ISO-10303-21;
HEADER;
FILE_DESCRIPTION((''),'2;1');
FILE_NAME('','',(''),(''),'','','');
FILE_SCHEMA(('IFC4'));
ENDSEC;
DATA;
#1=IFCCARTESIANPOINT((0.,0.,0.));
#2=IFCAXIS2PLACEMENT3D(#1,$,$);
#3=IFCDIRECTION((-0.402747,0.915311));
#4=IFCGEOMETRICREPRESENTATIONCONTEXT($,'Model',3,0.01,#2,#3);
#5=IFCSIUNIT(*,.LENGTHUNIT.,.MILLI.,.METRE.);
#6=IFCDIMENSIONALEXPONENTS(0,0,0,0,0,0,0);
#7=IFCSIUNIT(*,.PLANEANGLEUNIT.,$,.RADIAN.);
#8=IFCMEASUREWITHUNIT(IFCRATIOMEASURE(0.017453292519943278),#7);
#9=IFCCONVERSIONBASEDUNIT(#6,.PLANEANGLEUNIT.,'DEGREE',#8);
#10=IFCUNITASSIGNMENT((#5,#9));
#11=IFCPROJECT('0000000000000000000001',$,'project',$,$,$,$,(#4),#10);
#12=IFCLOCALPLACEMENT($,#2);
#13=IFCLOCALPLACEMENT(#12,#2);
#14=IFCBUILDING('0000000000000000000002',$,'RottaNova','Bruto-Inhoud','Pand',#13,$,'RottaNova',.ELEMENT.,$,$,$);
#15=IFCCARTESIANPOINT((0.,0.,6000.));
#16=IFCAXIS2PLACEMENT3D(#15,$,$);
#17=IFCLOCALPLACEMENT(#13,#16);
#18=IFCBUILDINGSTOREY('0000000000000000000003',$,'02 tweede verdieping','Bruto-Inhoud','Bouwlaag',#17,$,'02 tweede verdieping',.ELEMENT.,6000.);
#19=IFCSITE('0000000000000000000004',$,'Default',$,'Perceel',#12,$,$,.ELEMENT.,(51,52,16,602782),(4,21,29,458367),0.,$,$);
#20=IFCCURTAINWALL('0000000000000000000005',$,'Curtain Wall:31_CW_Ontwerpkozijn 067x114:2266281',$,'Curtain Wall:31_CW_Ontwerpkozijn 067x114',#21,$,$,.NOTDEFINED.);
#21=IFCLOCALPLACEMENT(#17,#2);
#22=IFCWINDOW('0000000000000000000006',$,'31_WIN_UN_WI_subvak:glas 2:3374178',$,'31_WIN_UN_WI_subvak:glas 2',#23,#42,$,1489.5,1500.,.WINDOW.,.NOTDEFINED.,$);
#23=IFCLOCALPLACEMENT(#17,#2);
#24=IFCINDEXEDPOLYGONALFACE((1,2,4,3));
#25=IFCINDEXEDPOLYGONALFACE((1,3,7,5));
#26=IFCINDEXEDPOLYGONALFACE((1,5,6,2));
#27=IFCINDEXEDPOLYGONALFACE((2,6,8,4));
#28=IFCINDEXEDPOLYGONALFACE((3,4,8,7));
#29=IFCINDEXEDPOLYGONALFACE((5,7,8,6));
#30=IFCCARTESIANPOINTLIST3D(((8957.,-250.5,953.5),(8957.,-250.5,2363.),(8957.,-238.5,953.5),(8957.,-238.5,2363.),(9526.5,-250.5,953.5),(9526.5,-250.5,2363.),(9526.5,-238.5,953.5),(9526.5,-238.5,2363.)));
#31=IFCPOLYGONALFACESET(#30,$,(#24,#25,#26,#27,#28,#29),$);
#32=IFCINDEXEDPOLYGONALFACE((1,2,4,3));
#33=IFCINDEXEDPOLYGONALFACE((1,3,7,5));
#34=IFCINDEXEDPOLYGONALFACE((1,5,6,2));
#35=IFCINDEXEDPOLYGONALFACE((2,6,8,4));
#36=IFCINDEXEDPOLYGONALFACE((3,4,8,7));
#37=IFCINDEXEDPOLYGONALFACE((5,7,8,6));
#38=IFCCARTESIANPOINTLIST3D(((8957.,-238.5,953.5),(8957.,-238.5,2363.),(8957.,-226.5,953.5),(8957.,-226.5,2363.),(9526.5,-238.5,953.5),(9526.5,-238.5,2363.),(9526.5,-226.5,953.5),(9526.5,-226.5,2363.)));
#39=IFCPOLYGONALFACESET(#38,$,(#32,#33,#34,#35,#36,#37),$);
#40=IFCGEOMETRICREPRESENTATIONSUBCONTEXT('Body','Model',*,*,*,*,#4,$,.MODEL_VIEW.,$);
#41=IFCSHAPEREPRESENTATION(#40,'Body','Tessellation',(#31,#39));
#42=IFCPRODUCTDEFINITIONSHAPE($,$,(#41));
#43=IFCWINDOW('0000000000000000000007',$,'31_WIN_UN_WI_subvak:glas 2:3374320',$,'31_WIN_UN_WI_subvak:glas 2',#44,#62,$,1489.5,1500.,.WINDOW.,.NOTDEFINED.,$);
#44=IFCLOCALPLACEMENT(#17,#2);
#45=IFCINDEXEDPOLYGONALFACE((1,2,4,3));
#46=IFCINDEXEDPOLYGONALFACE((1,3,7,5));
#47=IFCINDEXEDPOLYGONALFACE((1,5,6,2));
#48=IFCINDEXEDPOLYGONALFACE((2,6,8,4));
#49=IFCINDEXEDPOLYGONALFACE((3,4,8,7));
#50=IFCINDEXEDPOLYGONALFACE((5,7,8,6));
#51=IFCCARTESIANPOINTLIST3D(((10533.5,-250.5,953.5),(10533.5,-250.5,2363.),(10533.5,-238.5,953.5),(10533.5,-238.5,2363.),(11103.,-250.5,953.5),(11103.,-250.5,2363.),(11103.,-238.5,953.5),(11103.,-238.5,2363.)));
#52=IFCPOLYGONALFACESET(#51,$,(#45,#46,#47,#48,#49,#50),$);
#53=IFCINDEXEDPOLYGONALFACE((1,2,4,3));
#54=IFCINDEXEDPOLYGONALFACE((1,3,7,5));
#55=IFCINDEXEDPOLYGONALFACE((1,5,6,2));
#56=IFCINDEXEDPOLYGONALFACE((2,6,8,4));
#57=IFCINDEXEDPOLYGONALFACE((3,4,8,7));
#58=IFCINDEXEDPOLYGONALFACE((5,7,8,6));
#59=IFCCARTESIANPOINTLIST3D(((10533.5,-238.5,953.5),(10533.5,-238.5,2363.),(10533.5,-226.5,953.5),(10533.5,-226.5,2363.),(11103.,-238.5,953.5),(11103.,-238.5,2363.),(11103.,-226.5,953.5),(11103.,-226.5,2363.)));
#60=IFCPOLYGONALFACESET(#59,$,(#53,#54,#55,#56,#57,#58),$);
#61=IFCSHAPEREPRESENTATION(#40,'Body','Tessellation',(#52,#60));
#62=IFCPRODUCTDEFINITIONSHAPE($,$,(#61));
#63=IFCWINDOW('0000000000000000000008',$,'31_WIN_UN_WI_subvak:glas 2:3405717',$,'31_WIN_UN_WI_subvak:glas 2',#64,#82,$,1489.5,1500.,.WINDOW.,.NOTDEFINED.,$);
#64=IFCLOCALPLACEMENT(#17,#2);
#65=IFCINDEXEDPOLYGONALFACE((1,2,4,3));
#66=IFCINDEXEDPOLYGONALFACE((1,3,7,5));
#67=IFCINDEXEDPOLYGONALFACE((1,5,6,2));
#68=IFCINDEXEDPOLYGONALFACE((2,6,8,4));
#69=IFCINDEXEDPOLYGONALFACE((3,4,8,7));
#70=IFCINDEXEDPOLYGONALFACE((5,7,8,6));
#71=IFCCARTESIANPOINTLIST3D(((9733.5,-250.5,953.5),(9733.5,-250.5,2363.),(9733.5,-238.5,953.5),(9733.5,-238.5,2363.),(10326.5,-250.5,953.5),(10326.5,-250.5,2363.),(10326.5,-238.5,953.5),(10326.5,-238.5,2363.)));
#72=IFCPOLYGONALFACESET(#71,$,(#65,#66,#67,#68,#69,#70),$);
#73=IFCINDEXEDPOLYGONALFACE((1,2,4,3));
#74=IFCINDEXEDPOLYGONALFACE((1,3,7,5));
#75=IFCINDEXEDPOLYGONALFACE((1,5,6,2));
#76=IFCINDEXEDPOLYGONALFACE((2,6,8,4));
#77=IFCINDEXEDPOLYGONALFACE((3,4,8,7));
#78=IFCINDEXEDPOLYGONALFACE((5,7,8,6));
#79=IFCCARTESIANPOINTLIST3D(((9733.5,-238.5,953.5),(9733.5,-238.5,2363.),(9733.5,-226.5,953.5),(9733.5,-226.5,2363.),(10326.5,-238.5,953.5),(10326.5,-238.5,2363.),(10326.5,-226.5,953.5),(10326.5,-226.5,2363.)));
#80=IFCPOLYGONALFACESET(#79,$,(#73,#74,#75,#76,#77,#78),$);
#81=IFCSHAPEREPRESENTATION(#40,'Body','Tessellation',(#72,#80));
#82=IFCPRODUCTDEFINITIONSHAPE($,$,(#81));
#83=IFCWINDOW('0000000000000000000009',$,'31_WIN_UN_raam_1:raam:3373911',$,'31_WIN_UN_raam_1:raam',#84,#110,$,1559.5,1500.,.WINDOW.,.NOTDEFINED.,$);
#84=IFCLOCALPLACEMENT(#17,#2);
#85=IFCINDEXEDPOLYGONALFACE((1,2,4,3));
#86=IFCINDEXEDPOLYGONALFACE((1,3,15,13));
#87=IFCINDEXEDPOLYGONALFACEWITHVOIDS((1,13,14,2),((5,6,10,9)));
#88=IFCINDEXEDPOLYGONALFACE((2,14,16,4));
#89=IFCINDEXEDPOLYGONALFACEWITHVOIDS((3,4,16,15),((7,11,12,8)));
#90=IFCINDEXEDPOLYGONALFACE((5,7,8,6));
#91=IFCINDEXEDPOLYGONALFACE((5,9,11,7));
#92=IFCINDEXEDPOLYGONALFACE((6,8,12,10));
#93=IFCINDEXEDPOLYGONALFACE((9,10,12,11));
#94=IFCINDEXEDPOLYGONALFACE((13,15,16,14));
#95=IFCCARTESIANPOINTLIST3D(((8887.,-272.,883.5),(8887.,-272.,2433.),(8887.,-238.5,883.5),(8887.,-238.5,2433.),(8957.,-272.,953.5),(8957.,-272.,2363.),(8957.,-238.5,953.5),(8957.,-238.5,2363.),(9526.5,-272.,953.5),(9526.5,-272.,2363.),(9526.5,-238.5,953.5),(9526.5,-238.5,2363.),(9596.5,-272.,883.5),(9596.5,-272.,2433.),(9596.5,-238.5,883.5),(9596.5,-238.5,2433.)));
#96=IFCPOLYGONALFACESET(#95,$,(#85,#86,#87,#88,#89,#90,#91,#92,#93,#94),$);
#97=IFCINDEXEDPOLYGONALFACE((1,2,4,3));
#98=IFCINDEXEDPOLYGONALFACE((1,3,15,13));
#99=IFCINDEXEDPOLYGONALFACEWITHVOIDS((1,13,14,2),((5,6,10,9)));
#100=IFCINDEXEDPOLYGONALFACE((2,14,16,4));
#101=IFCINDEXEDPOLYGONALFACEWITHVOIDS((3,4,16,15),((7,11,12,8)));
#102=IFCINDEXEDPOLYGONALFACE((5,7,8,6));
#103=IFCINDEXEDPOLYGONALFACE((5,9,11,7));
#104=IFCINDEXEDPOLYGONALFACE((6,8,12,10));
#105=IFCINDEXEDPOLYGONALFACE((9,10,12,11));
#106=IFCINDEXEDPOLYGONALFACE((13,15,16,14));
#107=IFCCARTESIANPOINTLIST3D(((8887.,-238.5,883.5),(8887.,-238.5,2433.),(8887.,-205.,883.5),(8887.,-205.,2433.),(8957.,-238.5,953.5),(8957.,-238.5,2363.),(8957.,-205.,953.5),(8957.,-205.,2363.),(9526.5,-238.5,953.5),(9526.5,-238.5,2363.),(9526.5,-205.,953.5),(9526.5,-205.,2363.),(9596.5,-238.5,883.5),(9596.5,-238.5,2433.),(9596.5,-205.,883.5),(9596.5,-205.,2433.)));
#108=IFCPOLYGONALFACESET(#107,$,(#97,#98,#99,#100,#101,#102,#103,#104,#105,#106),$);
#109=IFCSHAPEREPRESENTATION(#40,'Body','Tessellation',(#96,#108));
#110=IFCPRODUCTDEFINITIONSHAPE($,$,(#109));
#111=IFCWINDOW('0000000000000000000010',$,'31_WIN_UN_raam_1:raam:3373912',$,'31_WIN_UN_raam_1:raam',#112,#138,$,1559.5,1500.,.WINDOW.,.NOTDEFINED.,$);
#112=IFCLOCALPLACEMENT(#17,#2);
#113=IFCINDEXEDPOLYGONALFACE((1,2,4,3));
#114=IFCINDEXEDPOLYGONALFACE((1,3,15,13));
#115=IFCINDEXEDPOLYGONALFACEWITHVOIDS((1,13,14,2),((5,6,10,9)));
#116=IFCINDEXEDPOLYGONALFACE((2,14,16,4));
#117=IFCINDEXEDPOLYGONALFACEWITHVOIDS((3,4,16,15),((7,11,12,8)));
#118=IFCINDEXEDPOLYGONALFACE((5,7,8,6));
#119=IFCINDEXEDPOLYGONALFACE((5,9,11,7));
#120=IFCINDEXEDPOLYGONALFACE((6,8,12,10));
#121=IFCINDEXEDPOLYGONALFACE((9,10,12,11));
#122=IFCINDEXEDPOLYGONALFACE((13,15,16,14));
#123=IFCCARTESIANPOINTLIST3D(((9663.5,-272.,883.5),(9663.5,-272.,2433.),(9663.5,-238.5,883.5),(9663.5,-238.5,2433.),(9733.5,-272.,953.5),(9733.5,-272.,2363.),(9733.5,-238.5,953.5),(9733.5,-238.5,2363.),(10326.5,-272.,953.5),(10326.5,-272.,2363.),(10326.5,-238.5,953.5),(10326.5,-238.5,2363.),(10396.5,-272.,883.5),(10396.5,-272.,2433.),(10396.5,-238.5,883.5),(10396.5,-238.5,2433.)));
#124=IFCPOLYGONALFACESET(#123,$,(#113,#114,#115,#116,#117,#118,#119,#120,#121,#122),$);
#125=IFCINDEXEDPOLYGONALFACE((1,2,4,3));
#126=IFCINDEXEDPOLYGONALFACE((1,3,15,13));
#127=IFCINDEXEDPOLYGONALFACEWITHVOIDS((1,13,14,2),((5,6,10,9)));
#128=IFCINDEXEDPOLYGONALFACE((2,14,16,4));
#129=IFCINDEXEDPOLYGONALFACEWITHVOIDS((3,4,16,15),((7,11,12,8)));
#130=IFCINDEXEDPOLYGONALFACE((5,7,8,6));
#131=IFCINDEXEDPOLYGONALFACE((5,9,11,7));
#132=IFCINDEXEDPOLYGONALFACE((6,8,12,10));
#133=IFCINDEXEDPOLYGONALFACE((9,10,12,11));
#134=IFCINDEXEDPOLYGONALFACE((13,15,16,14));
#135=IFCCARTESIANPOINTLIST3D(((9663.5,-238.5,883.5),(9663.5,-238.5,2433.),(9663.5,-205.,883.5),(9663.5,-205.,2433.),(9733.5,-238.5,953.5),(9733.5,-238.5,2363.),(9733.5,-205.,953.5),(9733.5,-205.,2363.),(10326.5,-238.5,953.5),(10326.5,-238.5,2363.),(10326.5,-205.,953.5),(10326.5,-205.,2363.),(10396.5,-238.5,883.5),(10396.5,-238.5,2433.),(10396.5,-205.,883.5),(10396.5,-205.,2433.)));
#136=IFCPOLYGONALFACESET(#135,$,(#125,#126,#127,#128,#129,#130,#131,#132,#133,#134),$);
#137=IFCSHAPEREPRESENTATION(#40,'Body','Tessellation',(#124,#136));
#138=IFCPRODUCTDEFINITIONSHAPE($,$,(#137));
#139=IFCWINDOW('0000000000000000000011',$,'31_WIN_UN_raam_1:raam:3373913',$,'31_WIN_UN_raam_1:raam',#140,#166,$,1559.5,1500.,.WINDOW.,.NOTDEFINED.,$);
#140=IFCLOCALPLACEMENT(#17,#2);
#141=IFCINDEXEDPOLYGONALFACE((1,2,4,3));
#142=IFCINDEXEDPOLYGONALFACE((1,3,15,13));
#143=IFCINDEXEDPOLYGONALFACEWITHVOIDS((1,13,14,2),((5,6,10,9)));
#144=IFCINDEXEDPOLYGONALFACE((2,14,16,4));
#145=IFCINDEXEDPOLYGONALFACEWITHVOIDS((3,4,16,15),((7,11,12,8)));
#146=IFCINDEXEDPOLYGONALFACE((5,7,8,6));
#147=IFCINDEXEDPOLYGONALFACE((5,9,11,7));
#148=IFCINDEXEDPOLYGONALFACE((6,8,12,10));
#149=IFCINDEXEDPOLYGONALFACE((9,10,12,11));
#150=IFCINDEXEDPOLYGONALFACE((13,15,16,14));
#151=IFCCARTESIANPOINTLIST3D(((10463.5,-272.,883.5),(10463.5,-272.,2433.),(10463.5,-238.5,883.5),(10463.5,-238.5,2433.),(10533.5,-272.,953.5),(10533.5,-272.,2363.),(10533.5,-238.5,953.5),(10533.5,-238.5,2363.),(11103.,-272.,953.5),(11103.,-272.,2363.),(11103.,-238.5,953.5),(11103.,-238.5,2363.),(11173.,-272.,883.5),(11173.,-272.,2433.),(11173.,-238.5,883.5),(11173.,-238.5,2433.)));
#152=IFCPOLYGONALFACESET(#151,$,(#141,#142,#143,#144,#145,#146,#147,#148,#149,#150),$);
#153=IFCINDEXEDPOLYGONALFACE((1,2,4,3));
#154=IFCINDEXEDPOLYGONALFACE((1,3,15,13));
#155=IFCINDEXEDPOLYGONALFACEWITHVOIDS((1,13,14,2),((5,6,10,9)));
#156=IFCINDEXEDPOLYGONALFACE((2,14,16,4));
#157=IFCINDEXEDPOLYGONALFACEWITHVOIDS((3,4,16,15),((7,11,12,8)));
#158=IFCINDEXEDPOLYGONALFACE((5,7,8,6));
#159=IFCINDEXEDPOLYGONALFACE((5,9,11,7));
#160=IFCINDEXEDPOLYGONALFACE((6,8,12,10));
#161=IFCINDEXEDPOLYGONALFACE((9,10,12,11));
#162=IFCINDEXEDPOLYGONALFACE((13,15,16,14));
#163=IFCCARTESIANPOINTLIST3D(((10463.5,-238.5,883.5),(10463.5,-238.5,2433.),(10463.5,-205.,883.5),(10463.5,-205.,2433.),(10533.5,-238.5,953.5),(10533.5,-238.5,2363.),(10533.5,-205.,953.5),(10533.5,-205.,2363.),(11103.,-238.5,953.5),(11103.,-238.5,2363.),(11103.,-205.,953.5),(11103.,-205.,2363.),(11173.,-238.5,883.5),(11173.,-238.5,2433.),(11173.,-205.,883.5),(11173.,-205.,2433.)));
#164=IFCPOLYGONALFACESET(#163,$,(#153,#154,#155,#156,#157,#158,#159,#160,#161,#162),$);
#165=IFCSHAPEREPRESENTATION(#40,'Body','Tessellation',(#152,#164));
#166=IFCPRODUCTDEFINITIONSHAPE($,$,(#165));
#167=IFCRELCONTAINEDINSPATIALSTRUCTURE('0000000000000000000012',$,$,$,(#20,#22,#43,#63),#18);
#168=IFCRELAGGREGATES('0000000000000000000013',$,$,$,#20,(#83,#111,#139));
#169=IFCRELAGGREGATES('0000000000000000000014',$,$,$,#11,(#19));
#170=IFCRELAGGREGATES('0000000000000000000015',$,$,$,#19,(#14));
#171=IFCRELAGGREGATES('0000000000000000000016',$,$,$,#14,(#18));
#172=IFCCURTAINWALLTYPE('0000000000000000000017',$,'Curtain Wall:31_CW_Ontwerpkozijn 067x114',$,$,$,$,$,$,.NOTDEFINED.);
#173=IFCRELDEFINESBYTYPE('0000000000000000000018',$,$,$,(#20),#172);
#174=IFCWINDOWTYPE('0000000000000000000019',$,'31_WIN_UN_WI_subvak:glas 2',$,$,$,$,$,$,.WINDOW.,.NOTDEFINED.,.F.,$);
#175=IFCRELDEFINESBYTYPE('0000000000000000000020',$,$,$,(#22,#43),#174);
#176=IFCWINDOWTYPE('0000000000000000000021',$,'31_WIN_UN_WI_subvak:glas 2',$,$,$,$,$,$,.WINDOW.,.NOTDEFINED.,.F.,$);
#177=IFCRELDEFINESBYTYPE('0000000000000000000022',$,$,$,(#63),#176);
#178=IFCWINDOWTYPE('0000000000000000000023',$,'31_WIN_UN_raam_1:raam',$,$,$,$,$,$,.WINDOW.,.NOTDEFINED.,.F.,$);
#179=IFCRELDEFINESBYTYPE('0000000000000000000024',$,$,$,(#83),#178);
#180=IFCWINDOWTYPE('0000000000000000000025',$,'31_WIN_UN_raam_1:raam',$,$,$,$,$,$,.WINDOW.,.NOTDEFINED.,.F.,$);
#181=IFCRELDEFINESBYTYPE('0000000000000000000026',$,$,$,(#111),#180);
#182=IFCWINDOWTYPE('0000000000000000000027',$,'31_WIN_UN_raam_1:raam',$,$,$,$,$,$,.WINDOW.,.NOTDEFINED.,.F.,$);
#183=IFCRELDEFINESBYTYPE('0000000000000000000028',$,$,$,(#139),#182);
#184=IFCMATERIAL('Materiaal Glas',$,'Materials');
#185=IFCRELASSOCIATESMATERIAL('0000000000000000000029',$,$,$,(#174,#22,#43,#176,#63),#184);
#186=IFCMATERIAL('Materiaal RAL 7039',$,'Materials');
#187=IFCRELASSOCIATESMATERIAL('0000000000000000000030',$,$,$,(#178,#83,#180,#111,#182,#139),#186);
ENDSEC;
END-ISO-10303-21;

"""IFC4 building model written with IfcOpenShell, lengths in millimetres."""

from ifc_helpers import new_model, entity, si_unit, converted_unit, direction, frame, origin, origin_2d_with_axis, place, context, subcontext, project, spatial, polyline, rectangle, outline, extrude, source, transform, mapped, material, type_object, type_shapes, element, aggregate, save


model = new_model("IFC4")

# Units and contexts
model_context = context("Model", 3, precision=0.01, world=origin(), true_north=direction((-0.402747, 0.915311)))
body_context = subcontext(model_context, "Body", "Model", "MODEL_VIEW")
ifc_project = project(units=[si_unit("LENGTHUNIT", "METRE", prefix="MILLI"), converted_unit("PLANEANGLEUNIT", "DEGREE", entity("IfcRatioMeasure", 0.017453292519943278), si_unit("PLANEANGLEUNIT", "RADIAN"), dimensions=[0, 0, 0, 0, 0, 0, 0])], contexts=[model_context])

# Site, building, storey
site_placement = place(None, origin())
site = spatial("IfcSite", under=ifc_project, at=site_placement, Name="Default", ObjectType="Perceel", CompositionType="ELEMENT", RefLatitude=(51, 52, 16, 602782), RefLongitude=(4, 21, 29, 458367), RefElevation=0.0)
building_placement = place(site_placement, origin())
building = spatial("IfcBuilding", under=site, at=building_placement, Name="RottaNova", Description="Bruto-Inhoud", ObjectType="Pand", LongName="RottaNova", CompositionType="ELEMENT")
storey_placement = place(building_placement, frame((0.0, 0.0, 6000.0)))
storey = spatial("IfcBuildingStorey", under=building, at=storey_placement, Name="02 tweede verdieping", Description="Bruto-Inhoud", ObjectType="Bouwlaag", LongName="02 tweede verdieping", CompositionType="ELEMENT", Elevation=6000.0)

# Curtain wall
curtain_wall_type = type_object("IfcCurtainWallType", Name="Curtain Wall:31_CW_Ontwerpkozijn 067x114", PredefinedType="NOTDEFINED")
curtain_wall_1_placement = place(storey_placement, frame((0.0, 0.0, -6000.0)))
curtain_wall_1 = element("IfcCurtainWall", 1, at=curtain_wall_1_placement, inside=storey, type_object=curtain_wall_type, Name="Curtain Wall:31_CW_Ontwerpkozijn 067x114:2266281", ObjectType="Curtain Wall:31_CW_Ontwerpkozijn 067x114", PredefinedType="NOTDEFINED")

# Shared definitions
ifc_material_1 = material(Name="Materiaal Glas", Category="Materials")

# Windows
window_type_1 = type_object("IfcWindowType", Name="31_WIN_UN_WI_subvak:glas 2", ParameterTakesPrecedence=False, PartitioningType="NOTDEFINED", PredefinedType="WINDOW", material=ifc_material_1)
shared_shape_1 = source(origin(), body_context, "Body", "SweptSolid", [
    extrude(rectangle(XDim=569.5, YDim=12.0, at=origin_2d_with_axis()), frame((0.0, -6.0, 0.0)), (0.0, 0.0, 1.0), 1409.5),
    extrude(rectangle(XDim=569.5, YDim=12.0, at=origin_2d_with_axis()), frame((0.0, 6.0, 0.0)), (0.0, 0.0, 1.0), 1409.5),
])
type_shapes(window_type_1, [shared_shape_1])
for number, where, name in (
    (2, (9241.7, -238.5, 953.5), "31_WIN_UN_WI_subvak:glas 2:3374178"),
    (3, (10818.2, -238.5, 953.5), "31_WIN_UN_WI_subvak:glas 2:3374320"),
):
    element("IfcWindow", number, at=place(storey_placement, frame(where)), inside=storey, type_object=window_type_1, material=ifc_material_1, Name=name, ObjectType="31_WIN_UN_WI_subvak:glas 2", OverallHeight=1489.5, OverallWidth=1500.0, PartitioningType="NOTDEFINED", PredefinedType="WINDOW", context=body_context, shape_type="MappedRepresentation", body=[
        mapped(shared_shape_1, transform((0.0, 0.0, 0.0), scale=1.0)),
    ])
window_type_2 = type_object("IfcWindowType", Name="31_WIN_UN_WI_subvak:glas 2", ParameterTakesPrecedence=False, PartitioningType="NOTDEFINED", PredefinedType="WINDOW", material=ifc_material_1)
shared_shape_2 = source(origin(), body_context, "Body", "SweptSolid", [
    extrude(rectangle(XDim=593.0, YDim=12.0, at=origin_2d_with_axis()), frame((0.0, -6.0, 0.0)), (0.0, 0.0, 1.0), 1409.5),
    extrude(rectangle(XDim=593.0, YDim=12.0, at=origin_2d_with_axis()), frame((0.0, 6.0, 0.0)), (0.0, 0.0, 1.0), 1409.5),
])
type_shapes(window_type_2, [shared_shape_2])
window_1_placement = place(storey_placement, frame((10030.0, -238.5, 953.5)))
element("IfcWindow", 4, at=window_1_placement, inside=storey, type_object=window_type_2, material=ifc_material_1, Name="31_WIN_UN_WI_subvak:glas 2:3405717", ObjectType="31_WIN_UN_WI_subvak:glas 2", OverallHeight=1489.5, OverallWidth=1500.0, PartitioningType="NOTDEFINED", PredefinedType="WINDOW", context=body_context, shape_type="MappedRepresentation", body=[
    mapped(shared_shape_2, transform((0.0, 0.0, 0.0), scale=1.0)),
])

# Windows
ifc_material_2 = material(Name="Materiaal RAL 7039", Category="Materials")
window_type_3 = type_object("IfcWindowType", Name="31_WIN_UN_raam_1:raam", ParameterTakesPrecedence=False, PartitioningType="NOTDEFINED", PredefinedType="WINDOW", material=ifc_material_2)
shared_shape_3 = source(origin(), body_context, "Body", "SweptSolid", [
    extrude(outline(polyline([(-354.7, -774.7), (354.7, -774.7), (354.7, 774.7), (-354.7, 774.7), (-354.7, -774.7)]), holes=[polyline([(-284.7, 704.7), (284.7, 704.7), (284.7, -704.8), (-284.7, -704.8), (-284.7, 704.7)])]), frame((0.0, 92.0, 774.8), z_axis=(0.0, -1.0, 0.0), x_axis=(-1.0, 0.0, 0.0)), (0.0, 0.0, 1.0), 33.5),
    extrude(outline(polyline([(-354.7, -774.7), (354.7, -774.7), (354.7, 774.7), (-354.7, 774.7), (-354.7, -774.7)]), holes=[polyline([(-284.7, 704.7), (284.7, 704.7), (284.7, -704.8), (-284.7, -704.8), (-284.7, 704.7)])]), frame((0.0, 58.5, 774.8), z_axis=(0.0, -1.0, 0.0), x_axis=(-1.0, 0.0, 0.0)), (0.0, 0.0, 1.0), 33.5),
])
type_shapes(window_type_3, [shared_shape_3])
window_2_placement = place(curtain_wall_1_placement, frame((9241.7, -180.0, 6883.5), z_axis=(0.0, 0.0, 1.0), x_axis=(-1.0, 0.0, 0.0)))
window_2 = element("IfcWindow", 5, at=window_2_placement, type_object=window_type_3, material=ifc_material_2, Name="31_WIN_UN_raam_1:raam:3373911", ObjectType="31_WIN_UN_raam_1:raam", OverallHeight=1559.5, OverallWidth=1500.0, PartitioningType="NOTDEFINED", PredefinedType="WINDOW", context=body_context, shape_type="MappedRepresentation", body=[
    mapped(shared_shape_3, transform((0.0, 0.0, 0.0), scale=1.0)),
])
window_type_4 = type_object("IfcWindowType", Name="31_WIN_UN_raam_1:raam", ParameterTakesPrecedence=False, PartitioningType="NOTDEFINED", PredefinedType="WINDOW", material=ifc_material_2)
shared_shape_4 = source(origin(), body_context, "Body", "SweptSolid", [
    extrude(outline(polyline([(-366.5, -774.7), (366.5, -774.7), (366.5, 774.7), (-366.5, 774.7), (-366.5, -774.7)]), holes=[polyline([(-296.5, 704.7), (296.5, 704.7), (296.5, -704.8), (-296.5, -704.8), (-296.5, 704.7)])]), frame((0.0, 92.0, 774.8), z_axis=(0.0, -1.0, 0.0), x_axis=(-1.0, 0.0, 0.0)), (0.0, 0.0, 1.0), 33.5),
    extrude(outline(polyline([(-366.5, -774.7), (366.5, -774.7), (366.5, 774.7), (-366.5, 774.7), (-366.5, -774.7)]), holes=[polyline([(-296.5, 704.7), (296.5, 704.7), (296.5, -704.8), (-296.5, -704.8), (-296.5, 704.7)])]), frame((0.0, 58.5, 774.8), z_axis=(0.0, -1.0, 0.0), x_axis=(-1.0, 0.0, 0.0)), (0.0, 0.0, 1.0), 33.5),
])
type_shapes(window_type_4, [shared_shape_4])
window_3_placement = place(curtain_wall_1_placement, frame((10030.0, -180.0, 6883.5), z_axis=(0.0, 0.0, 1.0), x_axis=(-1.0, 0.0, 0.0)))
window_3 = element("IfcWindow", 6, at=window_3_placement, type_object=window_type_4, material=ifc_material_2, Name="31_WIN_UN_raam_1:raam:3373912", ObjectType="31_WIN_UN_raam_1:raam", OverallHeight=1559.5, OverallWidth=1500.0, PartitioningType="NOTDEFINED", PredefinedType="WINDOW", context=body_context, shape_type="MappedRepresentation", body=[
    mapped(shared_shape_4, transform((0.0, 0.0, 0.0), scale=1.0)),
])
window_type_5 = type_object("IfcWindowType", Name="31_WIN_UN_raam_1:raam", ParameterTakesPrecedence=False, PartitioningType="NOTDEFINED", PredefinedType="WINDOW", material=ifc_material_2)
shared_shape_5 = source(origin(), body_context, "Body", "SweptSolid", [
    extrude(outline(polyline([(-354.7, -774.7), (354.7, -774.7), (354.7, 774.7), (-354.7, 774.7), (-354.7, -774.7)]), holes=[polyline([(-284.7, 704.7), (284.7, 704.7), (284.7, -704.8), (-284.7, -704.8), (-284.7, 704.7)])]), frame((0.0, 92.0, 774.8), z_axis=(0.0, -1.0, 0.0), x_axis=(-1.0, 0.0, 0.0)), (0.0, 0.0, 1.0), 33.5),
    extrude(outline(polyline([(-354.7, -774.7), (354.7, -774.7), (354.7, 774.7), (-354.7, 774.7), (-354.7, -774.7)]), holes=[polyline([(-284.7, 704.7), (284.7, 704.7), (284.7, -704.8), (-284.7, -704.8), (-284.7, 704.7)])]), frame((0.0, 58.5, 774.8), z_axis=(0.0, -1.0, 0.0), x_axis=(-1.0, 0.0, 0.0)), (0.0, 0.0, 1.0), 33.5),
])
type_shapes(window_type_5, [shared_shape_5])
window_4_placement = place(curtain_wall_1_placement, frame((10818.2, -180.0, 6883.5), z_axis=(0.0, 0.0, 1.0), x_axis=(-1.0, 0.0, 0.0)))
window_4 = element("IfcWindow", 7, at=window_4_placement, type_object=window_type_5, material=ifc_material_2, Name="31_WIN_UN_raam_1:raam:3373913", ObjectType="31_WIN_UN_raam_1:raam", OverallHeight=1559.5, OverallWidth=1500.0, PartitioningType="NOTDEFINED", PredefinedType="WINDOW", context=body_context, shape_type="MappedRepresentation", body=[
    mapped(shared_shape_5, transform((0.0, 0.0, 0.0), scale=1.0)),
])
aggregate(curtain_wall_1, [window_2, window_3, window_4])

save(model, "model.ifc")
